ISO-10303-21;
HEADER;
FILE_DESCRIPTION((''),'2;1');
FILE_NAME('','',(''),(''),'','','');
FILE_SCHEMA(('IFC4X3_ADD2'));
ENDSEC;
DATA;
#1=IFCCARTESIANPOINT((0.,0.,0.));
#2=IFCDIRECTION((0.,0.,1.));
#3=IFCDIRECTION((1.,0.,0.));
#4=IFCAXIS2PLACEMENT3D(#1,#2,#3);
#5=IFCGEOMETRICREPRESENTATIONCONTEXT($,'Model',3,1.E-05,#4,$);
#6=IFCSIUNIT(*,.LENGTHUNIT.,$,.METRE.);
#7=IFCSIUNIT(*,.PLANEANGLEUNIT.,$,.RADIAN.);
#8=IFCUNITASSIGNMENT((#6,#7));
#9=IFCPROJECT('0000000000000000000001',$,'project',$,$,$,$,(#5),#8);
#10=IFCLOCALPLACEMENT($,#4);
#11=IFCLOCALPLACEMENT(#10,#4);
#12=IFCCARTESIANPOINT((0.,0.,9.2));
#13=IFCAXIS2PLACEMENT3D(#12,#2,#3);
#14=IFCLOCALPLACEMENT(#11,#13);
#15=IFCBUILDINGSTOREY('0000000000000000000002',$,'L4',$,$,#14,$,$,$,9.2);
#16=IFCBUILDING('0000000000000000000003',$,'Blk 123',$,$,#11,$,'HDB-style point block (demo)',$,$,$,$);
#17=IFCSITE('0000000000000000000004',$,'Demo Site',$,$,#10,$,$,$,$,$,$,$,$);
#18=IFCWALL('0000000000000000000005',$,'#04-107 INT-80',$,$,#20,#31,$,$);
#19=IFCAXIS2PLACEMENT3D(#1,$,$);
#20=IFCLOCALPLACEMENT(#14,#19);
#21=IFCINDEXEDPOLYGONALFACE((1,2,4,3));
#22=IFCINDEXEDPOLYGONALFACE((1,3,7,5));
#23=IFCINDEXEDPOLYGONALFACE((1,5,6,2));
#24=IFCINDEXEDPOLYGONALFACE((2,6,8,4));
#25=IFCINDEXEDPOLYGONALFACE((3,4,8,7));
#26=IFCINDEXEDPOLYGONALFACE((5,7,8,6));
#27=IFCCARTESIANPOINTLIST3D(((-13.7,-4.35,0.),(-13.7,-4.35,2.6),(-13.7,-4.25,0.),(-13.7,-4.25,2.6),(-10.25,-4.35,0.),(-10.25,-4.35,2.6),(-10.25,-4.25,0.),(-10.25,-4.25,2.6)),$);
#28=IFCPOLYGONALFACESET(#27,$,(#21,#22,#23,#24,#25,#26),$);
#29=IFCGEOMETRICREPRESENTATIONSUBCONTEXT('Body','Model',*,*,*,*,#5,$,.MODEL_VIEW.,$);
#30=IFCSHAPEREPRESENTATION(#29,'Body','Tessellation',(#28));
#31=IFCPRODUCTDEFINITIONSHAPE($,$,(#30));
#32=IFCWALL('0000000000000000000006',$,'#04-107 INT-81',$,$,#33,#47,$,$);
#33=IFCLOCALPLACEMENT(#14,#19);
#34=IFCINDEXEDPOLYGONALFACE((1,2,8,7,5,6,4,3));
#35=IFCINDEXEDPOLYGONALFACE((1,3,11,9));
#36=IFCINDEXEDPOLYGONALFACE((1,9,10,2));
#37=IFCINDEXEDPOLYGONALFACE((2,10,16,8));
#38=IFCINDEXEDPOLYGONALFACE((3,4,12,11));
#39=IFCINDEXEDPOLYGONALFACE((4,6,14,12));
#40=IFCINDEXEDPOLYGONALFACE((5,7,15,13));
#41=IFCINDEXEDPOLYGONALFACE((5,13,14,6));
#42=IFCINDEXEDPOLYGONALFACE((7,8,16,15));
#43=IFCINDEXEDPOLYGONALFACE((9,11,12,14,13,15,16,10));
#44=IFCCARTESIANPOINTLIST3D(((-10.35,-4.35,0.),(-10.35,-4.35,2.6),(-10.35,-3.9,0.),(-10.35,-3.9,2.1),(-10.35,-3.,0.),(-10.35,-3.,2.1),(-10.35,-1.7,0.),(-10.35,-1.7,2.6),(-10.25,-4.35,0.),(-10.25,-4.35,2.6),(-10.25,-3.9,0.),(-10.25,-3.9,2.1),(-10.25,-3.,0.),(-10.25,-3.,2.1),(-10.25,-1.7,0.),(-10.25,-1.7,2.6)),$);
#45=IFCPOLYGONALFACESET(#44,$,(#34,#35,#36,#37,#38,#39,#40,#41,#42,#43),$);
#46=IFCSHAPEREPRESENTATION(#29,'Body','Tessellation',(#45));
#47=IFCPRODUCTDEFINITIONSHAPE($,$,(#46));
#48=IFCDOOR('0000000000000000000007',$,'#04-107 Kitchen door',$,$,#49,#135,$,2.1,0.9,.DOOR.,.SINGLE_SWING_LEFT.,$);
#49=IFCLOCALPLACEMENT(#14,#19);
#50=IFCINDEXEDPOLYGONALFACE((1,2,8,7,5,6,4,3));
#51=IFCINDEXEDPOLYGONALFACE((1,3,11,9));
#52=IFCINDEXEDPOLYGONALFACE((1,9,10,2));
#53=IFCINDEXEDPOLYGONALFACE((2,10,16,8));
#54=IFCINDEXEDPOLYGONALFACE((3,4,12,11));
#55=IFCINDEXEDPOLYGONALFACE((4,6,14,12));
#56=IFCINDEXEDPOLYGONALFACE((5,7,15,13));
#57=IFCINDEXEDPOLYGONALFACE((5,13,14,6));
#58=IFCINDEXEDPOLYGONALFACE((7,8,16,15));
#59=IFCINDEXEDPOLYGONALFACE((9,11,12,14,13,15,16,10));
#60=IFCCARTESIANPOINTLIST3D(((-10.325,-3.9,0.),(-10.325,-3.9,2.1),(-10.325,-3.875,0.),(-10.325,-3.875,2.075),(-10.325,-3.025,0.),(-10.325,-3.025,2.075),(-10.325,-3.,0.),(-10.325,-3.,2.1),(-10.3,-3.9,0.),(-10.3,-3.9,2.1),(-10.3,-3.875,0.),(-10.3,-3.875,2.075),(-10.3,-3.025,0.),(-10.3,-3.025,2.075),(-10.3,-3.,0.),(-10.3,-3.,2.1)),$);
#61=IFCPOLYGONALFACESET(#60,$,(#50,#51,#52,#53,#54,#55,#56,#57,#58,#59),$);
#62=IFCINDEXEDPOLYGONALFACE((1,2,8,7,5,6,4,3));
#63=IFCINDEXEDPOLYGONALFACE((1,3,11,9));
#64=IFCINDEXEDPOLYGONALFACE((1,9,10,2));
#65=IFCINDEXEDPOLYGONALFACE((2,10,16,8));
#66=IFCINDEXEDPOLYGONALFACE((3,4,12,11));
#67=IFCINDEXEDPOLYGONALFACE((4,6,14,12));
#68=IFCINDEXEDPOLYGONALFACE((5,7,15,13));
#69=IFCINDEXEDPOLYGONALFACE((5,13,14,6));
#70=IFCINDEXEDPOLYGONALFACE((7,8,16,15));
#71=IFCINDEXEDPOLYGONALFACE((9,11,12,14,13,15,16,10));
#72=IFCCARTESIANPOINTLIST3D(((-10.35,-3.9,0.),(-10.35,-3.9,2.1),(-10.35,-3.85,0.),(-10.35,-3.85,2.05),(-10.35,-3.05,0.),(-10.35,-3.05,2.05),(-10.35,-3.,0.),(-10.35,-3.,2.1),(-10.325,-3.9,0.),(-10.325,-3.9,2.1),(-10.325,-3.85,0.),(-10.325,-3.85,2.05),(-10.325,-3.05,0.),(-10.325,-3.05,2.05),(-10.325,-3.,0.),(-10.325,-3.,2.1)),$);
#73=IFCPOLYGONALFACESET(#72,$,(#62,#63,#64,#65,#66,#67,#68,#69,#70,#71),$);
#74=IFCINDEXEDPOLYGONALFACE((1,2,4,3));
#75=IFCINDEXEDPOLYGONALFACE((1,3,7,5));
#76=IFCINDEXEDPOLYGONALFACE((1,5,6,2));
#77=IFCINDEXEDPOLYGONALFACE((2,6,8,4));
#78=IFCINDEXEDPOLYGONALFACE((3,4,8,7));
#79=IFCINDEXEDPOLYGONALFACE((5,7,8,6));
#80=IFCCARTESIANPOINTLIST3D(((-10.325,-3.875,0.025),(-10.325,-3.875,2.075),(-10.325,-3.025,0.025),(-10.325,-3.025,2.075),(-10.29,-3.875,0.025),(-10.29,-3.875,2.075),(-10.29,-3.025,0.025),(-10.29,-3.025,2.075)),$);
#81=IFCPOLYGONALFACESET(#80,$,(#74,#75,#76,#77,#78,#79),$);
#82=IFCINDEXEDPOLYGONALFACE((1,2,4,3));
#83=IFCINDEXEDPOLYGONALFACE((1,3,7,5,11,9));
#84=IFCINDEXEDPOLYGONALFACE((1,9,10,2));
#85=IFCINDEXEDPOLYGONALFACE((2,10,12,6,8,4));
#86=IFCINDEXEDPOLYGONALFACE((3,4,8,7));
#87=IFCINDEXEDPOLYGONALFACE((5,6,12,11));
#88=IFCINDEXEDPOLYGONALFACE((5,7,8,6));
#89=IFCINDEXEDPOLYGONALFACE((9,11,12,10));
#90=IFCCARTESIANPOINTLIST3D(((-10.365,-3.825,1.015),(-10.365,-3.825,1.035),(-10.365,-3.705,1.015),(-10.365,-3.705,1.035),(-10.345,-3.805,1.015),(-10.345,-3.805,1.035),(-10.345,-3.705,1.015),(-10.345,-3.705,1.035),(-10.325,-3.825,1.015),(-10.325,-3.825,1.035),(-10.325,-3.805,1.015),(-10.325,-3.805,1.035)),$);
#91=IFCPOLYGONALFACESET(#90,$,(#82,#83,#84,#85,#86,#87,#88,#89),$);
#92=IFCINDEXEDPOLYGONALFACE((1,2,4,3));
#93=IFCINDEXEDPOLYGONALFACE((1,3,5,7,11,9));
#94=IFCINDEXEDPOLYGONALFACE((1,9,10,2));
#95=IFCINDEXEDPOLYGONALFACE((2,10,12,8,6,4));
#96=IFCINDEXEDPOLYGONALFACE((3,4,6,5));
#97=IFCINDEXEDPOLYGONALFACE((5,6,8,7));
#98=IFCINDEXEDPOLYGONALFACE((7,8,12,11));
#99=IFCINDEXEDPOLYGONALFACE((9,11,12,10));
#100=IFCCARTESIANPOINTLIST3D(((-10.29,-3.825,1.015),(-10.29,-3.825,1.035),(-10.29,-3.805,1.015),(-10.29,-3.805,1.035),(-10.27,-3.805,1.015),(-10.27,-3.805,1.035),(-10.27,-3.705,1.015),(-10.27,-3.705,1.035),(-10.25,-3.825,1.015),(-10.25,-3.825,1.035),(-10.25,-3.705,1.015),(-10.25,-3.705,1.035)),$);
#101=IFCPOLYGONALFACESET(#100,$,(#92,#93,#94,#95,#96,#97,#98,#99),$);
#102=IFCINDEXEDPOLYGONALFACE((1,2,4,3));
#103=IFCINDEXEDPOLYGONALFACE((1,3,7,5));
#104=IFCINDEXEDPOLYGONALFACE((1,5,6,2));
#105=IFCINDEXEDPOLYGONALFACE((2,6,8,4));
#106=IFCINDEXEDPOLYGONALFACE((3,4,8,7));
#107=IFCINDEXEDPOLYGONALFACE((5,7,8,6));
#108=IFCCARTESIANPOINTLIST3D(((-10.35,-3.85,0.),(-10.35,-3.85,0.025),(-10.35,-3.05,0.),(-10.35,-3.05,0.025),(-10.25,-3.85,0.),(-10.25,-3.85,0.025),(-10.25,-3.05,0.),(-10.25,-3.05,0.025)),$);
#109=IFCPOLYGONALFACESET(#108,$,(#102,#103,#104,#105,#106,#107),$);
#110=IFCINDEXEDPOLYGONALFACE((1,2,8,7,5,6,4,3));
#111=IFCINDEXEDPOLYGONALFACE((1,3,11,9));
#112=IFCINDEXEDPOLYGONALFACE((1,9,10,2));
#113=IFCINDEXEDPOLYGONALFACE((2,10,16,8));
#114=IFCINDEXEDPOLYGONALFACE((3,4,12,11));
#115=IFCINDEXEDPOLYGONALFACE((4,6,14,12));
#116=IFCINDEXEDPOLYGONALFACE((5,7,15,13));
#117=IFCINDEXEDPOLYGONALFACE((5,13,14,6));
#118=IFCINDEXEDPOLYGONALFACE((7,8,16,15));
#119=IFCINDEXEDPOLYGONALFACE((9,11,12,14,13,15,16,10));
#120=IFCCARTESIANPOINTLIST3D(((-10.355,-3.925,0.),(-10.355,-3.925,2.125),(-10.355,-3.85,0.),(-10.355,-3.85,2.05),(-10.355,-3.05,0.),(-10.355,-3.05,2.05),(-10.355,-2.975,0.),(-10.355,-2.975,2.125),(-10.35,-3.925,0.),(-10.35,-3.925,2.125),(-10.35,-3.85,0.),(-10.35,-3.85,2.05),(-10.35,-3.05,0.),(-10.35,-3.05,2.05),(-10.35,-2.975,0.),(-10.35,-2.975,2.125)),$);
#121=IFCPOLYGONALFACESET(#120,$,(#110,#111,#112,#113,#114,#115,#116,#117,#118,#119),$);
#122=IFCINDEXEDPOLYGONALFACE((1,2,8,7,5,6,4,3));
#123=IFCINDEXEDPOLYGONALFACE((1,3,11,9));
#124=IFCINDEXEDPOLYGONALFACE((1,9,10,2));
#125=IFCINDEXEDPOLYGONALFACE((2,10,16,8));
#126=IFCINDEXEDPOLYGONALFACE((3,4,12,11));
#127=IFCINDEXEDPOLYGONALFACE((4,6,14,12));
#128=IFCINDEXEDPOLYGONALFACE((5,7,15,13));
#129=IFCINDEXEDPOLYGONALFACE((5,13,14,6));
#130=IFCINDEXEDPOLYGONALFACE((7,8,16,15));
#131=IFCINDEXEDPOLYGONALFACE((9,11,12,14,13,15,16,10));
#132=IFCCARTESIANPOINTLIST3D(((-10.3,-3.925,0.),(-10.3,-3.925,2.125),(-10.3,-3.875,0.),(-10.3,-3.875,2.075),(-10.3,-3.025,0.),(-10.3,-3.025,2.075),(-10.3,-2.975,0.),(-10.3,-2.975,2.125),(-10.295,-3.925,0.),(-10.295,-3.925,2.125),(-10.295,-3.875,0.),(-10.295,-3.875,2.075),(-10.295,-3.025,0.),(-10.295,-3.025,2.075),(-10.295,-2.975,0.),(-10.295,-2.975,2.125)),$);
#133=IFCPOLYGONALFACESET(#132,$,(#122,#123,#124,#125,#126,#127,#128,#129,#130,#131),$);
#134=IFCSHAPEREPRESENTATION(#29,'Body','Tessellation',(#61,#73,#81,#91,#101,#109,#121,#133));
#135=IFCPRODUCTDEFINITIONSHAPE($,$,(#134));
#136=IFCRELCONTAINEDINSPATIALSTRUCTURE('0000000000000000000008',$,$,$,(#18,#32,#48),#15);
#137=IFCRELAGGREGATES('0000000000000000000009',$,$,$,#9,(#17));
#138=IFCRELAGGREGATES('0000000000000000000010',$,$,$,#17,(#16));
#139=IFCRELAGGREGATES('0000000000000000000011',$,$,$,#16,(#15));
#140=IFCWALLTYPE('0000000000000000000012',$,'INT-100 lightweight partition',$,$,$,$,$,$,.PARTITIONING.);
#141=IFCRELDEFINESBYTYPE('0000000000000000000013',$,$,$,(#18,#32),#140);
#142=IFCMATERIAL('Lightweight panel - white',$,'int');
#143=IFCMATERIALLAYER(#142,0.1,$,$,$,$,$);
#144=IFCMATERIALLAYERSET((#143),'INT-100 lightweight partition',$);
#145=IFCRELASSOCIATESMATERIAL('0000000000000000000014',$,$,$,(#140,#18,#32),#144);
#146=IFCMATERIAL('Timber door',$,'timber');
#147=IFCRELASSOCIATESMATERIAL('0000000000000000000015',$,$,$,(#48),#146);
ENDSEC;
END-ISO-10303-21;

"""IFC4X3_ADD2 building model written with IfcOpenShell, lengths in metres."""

from ifc_helpers import new_model, si_unit, frame, origin_with_axes, place, context, subcontext, project, spatial, line, indexed_curve, outline, extrude, material, layer, layer_set, layer_usage, type_object, element, fill, save


model = new_model("IFC4X3_ADD2")

# Units and contexts
model_context = context("Model", 3, precision=1e-05, world=origin_with_axes())
body_context = subcontext(model_context, "Body", "Model", "MODEL_VIEW")
ifc_project = project(units=[si_unit("LENGTHUNIT", "METRE"), si_unit("PLANEANGLEUNIT", "RADIAN")], contexts=[model_context])

# Site, building, storey
site_placement = place(None, origin_with_axes())
site = spatial("IfcSite", under=ifc_project, at=site_placement, Name="Demo Site")
building_placement = place(site_placement, origin_with_axes())
building = spatial("IfcBuilding", under=site, at=building_placement, Name="Blk 123", LongName="HDB-style point block (demo)")
storey_placement = place(building_placement, frame((0.0, 0.0, 9.2), z_axis=(0.0, 0.0, 1.0), x_axis=(1.0, 0.0, 0.0)))
storey = spatial("IfcBuildingStorey", under=building, at=storey_placement, Name="L4", Elevation=9.2)

# Wall
ifc_material_1 = material(Name="Lightweight panel - white", Category="int")
ifc_layer_1 = layer(ifc_material_1, 0.1)
ifc_layer_set_1 = layer_set([ifc_layer_1], Name="INT-100 lightweight partition")
ifc_layer_usage_1 = layer_usage(ifc_layer_set_1, "AXIS2", "POSITIVE", -0.05)
wall_type_1 = type_object("IfcWallType", Name="INT-100 lightweight partition", PredefinedType="PARTITIONING", material=ifc_layer_set_1)
wall_1_placement = place(storey_placement, frame((-10.25, -4.3, 0.0), z_axis=(0.0, 0.0, 1.0), x_axis=(-1.0, 0.0, 0.0)))
element("IfcWall", 1, at=wall_1_placement, inside=storey, type_object=wall_type_1, material=ifc_layer_usage_1, Name="#04-107 INT-80", context=body_context, shape_type="SweptSolid", body=[
    extrude(outline(indexed_curve([(0.0, 0.0), (0.0, 0.1), (3.45, 0.1), (3.45, 0.0), (0.0, 0.0)], self_intersect=False)), frame((0.0, -0.05, 0.0), z_axis=(0.0, 0.0, 1.0), x_axis=(1.0, 0.0, 0.0)), (0.0, 0.0, 1.0), 2.6),
])

# Wall, opening, door
wall_2_placement = place(storey_placement, frame((-10.3, -1.7, 0.0), z_axis=(0.0, 0.0, 1.0), x_axis=(0.0, -1.0, 0.0)))
wall_2 = element("IfcWall", 2, at=wall_2_placement, inside=storey, type_object=wall_type_1, material=ifc_layer_usage_1, Name="#04-107 INT-81", context=body_context, shape_type="SweptSolid", body=[
    extrude(outline(indexed_curve([(0.0, 0.0), (0.0, 0.1), (2.65, 0.1), (2.65, 0.0), (0.0, 0.0)], self_intersect=False)), frame((0.0, -0.05, 0.0), z_axis=(0.0, 0.0, 1.0), x_axis=(1.0, 0.0, 0.0)), (0.0, 0.0, 1.0), 2.6),
])
opening_1_placement = place(wall_2_placement, frame((1.3, -0.15, 0.0), z_axis=(0.0, 0.0, 1.0), x_axis=(1.0, 0.0, 0.0)))
opening_1 = element("IfcOpeningElement", 3, at=opening_1_placement, cuts=wall_2, context=body_context, shape_type="SweptSolid", body=[
    extrude(outline(indexed_curve([(0.0, 0.0), (0.0, 0.3), (0.9, 0.3), (0.9, 0.0), (0.0, 0.0)], self_intersect=False)), origin_with_axes(), (0.0, 0.0, 1.0), 2.1),
])
ifc_material_2 = material(Name="Timber door", Category="timber")
door_1_placement = place(opening_1_placement, frame((0.0, 0.1, 0.0), z_axis=(0.0, 0.0, 1.0), x_axis=(1.0, 0.0, 0.0)))
door_1 = element("IfcDoor", 4, at=door_1_placement, inside=storey, material=ifc_material_2, Name="#04-107 Kitchen door", OperationType="SINGLE_SWING_LEFT", OverallHeight=2.1, OverallWidth=0.9, PredefinedType="DOOR", context=body_context, shape_type="SweptSolid", body=[
    extrude(outline(indexed_curve([(0.0, 0.0), (0.0, 2.1), (0.9, 2.1), (0.9, 0.0), (0.875, 0.0), (0.875, 2.075), (0.025, 2.075), (0.025, 0.0)], segments=[line(1, 2, 3, 4, 5, 6, 7, 8, 1)])), frame((0.0, 0.025, 0.0), z_axis=(0.0, -1.0, 0.0), x_axis=(1.0, 0.0, 0.0)), (0.0, 0.0, -1.0), 0.025),
    extrude(outline(indexed_curve([(0.0, 0.0), (0.0, 2.1), (0.9, 2.1), (0.9, 0.0), (0.85, 0.0), (0.85, 2.05), (0.05, 2.05), (0.05, 0.0)], segments=[line(1, 2, 3, 4, 5, 6, 7, 8, 1)])), frame((0.0, 0.0, 0.0), z_axis=(0.0, -1.0, 0.0), x_axis=(1.0, 0.0, 0.0)), (0.0, 0.0, -1.0), 0.025),
    extrude(outline(indexed_curve([(0.0, 0.0), (0.85, 0.0), (0.85, 0.035), (0.0, 0.035)], segments=[line(1, 2, 3, 4, 1)])), frame((0.025, 0.025, 0.025), z_axis=(0.0, 0.0, 1.0), x_axis=(1.0, 0.0, 0.0)), (0.0, 0.0, 1.0), 2.05),
    extrude(outline(indexed_curve([(0.0, 0.0), (0.0, -0.04), (-0.12, -0.04), (-0.12, -0.02), (-0.02, -0.02), (-0.02, 0.0)], segments=[line(1, 2, 3, 4, 5, 6, 1)])), frame((0.825, 0.025, 1.015), z_axis=(0.0, 0.0, 1.0), x_axis=(1.0, 0.0, 0.0)), (0.0, 0.0, 1.0), 0.02),
    extrude(outline(indexed_curve([(0.0, 0.0), (0.0, 0.04), (-0.12, 0.04), (-0.12, 0.02), (-0.02, 0.02), (-0.02, 0.0)], segments=[line(1, 2, 3, 4, 5, 6, 1)])), frame((0.825, 0.06, 1.015), z_axis=(0.0, 0.0, 1.0), x_axis=(1.0, 0.0, 0.0)), (0.0, 0.0, 1.0), 0.02),
    extrude(outline(indexed_curve([(0.0, 0.0), (0.8, 0.0), (0.8, 0.1), (0.0, 0.1)], segments=[line(1, 2, 3, 4, 1)])), frame((0.05, 0.0, 0.0), z_axis=(0.0, 0.0, 1.0), x_axis=(1.0, 0.0, 0.0)), (0.0, 0.0, 1.0), 0.025),
    extrude(outline(indexed_curve([(0.0, 0.0), (0.0, 2.125), (0.95, 2.125), (0.95, 0.0), (0.875, 0.0), (0.875, 2.05), (0.075, 2.05), (0.075, 0.0)], segments=[line(1, 2, 3, 4, 5, 6, 7, 8, 1)])), frame((-0.025, -0.005, 0.0), z_axis=(0.0, -1.0, 0.0), x_axis=(1.0, 0.0, 0.0)), (0.0, 0.0, -1.0), 0.005),
    extrude(outline(indexed_curve([(0.0, 0.0), (0.0, 2.125), (0.95, 2.125), (0.95, 0.0), (0.9, 0.0), (0.9, 2.075), (0.05, 2.075), (0.05, 0.0)], segments=[line(1, 2, 3, 4, 5, 6, 7, 8, 1)])), frame((-0.025, 0.05, 0.0), z_axis=(0.0, -1.0, 0.0), x_axis=(1.0, 0.0, 0.0)), (0.0, 0.0, -1.0), 0.005),
])
fill(opening_1, door_1)

save(model, "model.ifc")
